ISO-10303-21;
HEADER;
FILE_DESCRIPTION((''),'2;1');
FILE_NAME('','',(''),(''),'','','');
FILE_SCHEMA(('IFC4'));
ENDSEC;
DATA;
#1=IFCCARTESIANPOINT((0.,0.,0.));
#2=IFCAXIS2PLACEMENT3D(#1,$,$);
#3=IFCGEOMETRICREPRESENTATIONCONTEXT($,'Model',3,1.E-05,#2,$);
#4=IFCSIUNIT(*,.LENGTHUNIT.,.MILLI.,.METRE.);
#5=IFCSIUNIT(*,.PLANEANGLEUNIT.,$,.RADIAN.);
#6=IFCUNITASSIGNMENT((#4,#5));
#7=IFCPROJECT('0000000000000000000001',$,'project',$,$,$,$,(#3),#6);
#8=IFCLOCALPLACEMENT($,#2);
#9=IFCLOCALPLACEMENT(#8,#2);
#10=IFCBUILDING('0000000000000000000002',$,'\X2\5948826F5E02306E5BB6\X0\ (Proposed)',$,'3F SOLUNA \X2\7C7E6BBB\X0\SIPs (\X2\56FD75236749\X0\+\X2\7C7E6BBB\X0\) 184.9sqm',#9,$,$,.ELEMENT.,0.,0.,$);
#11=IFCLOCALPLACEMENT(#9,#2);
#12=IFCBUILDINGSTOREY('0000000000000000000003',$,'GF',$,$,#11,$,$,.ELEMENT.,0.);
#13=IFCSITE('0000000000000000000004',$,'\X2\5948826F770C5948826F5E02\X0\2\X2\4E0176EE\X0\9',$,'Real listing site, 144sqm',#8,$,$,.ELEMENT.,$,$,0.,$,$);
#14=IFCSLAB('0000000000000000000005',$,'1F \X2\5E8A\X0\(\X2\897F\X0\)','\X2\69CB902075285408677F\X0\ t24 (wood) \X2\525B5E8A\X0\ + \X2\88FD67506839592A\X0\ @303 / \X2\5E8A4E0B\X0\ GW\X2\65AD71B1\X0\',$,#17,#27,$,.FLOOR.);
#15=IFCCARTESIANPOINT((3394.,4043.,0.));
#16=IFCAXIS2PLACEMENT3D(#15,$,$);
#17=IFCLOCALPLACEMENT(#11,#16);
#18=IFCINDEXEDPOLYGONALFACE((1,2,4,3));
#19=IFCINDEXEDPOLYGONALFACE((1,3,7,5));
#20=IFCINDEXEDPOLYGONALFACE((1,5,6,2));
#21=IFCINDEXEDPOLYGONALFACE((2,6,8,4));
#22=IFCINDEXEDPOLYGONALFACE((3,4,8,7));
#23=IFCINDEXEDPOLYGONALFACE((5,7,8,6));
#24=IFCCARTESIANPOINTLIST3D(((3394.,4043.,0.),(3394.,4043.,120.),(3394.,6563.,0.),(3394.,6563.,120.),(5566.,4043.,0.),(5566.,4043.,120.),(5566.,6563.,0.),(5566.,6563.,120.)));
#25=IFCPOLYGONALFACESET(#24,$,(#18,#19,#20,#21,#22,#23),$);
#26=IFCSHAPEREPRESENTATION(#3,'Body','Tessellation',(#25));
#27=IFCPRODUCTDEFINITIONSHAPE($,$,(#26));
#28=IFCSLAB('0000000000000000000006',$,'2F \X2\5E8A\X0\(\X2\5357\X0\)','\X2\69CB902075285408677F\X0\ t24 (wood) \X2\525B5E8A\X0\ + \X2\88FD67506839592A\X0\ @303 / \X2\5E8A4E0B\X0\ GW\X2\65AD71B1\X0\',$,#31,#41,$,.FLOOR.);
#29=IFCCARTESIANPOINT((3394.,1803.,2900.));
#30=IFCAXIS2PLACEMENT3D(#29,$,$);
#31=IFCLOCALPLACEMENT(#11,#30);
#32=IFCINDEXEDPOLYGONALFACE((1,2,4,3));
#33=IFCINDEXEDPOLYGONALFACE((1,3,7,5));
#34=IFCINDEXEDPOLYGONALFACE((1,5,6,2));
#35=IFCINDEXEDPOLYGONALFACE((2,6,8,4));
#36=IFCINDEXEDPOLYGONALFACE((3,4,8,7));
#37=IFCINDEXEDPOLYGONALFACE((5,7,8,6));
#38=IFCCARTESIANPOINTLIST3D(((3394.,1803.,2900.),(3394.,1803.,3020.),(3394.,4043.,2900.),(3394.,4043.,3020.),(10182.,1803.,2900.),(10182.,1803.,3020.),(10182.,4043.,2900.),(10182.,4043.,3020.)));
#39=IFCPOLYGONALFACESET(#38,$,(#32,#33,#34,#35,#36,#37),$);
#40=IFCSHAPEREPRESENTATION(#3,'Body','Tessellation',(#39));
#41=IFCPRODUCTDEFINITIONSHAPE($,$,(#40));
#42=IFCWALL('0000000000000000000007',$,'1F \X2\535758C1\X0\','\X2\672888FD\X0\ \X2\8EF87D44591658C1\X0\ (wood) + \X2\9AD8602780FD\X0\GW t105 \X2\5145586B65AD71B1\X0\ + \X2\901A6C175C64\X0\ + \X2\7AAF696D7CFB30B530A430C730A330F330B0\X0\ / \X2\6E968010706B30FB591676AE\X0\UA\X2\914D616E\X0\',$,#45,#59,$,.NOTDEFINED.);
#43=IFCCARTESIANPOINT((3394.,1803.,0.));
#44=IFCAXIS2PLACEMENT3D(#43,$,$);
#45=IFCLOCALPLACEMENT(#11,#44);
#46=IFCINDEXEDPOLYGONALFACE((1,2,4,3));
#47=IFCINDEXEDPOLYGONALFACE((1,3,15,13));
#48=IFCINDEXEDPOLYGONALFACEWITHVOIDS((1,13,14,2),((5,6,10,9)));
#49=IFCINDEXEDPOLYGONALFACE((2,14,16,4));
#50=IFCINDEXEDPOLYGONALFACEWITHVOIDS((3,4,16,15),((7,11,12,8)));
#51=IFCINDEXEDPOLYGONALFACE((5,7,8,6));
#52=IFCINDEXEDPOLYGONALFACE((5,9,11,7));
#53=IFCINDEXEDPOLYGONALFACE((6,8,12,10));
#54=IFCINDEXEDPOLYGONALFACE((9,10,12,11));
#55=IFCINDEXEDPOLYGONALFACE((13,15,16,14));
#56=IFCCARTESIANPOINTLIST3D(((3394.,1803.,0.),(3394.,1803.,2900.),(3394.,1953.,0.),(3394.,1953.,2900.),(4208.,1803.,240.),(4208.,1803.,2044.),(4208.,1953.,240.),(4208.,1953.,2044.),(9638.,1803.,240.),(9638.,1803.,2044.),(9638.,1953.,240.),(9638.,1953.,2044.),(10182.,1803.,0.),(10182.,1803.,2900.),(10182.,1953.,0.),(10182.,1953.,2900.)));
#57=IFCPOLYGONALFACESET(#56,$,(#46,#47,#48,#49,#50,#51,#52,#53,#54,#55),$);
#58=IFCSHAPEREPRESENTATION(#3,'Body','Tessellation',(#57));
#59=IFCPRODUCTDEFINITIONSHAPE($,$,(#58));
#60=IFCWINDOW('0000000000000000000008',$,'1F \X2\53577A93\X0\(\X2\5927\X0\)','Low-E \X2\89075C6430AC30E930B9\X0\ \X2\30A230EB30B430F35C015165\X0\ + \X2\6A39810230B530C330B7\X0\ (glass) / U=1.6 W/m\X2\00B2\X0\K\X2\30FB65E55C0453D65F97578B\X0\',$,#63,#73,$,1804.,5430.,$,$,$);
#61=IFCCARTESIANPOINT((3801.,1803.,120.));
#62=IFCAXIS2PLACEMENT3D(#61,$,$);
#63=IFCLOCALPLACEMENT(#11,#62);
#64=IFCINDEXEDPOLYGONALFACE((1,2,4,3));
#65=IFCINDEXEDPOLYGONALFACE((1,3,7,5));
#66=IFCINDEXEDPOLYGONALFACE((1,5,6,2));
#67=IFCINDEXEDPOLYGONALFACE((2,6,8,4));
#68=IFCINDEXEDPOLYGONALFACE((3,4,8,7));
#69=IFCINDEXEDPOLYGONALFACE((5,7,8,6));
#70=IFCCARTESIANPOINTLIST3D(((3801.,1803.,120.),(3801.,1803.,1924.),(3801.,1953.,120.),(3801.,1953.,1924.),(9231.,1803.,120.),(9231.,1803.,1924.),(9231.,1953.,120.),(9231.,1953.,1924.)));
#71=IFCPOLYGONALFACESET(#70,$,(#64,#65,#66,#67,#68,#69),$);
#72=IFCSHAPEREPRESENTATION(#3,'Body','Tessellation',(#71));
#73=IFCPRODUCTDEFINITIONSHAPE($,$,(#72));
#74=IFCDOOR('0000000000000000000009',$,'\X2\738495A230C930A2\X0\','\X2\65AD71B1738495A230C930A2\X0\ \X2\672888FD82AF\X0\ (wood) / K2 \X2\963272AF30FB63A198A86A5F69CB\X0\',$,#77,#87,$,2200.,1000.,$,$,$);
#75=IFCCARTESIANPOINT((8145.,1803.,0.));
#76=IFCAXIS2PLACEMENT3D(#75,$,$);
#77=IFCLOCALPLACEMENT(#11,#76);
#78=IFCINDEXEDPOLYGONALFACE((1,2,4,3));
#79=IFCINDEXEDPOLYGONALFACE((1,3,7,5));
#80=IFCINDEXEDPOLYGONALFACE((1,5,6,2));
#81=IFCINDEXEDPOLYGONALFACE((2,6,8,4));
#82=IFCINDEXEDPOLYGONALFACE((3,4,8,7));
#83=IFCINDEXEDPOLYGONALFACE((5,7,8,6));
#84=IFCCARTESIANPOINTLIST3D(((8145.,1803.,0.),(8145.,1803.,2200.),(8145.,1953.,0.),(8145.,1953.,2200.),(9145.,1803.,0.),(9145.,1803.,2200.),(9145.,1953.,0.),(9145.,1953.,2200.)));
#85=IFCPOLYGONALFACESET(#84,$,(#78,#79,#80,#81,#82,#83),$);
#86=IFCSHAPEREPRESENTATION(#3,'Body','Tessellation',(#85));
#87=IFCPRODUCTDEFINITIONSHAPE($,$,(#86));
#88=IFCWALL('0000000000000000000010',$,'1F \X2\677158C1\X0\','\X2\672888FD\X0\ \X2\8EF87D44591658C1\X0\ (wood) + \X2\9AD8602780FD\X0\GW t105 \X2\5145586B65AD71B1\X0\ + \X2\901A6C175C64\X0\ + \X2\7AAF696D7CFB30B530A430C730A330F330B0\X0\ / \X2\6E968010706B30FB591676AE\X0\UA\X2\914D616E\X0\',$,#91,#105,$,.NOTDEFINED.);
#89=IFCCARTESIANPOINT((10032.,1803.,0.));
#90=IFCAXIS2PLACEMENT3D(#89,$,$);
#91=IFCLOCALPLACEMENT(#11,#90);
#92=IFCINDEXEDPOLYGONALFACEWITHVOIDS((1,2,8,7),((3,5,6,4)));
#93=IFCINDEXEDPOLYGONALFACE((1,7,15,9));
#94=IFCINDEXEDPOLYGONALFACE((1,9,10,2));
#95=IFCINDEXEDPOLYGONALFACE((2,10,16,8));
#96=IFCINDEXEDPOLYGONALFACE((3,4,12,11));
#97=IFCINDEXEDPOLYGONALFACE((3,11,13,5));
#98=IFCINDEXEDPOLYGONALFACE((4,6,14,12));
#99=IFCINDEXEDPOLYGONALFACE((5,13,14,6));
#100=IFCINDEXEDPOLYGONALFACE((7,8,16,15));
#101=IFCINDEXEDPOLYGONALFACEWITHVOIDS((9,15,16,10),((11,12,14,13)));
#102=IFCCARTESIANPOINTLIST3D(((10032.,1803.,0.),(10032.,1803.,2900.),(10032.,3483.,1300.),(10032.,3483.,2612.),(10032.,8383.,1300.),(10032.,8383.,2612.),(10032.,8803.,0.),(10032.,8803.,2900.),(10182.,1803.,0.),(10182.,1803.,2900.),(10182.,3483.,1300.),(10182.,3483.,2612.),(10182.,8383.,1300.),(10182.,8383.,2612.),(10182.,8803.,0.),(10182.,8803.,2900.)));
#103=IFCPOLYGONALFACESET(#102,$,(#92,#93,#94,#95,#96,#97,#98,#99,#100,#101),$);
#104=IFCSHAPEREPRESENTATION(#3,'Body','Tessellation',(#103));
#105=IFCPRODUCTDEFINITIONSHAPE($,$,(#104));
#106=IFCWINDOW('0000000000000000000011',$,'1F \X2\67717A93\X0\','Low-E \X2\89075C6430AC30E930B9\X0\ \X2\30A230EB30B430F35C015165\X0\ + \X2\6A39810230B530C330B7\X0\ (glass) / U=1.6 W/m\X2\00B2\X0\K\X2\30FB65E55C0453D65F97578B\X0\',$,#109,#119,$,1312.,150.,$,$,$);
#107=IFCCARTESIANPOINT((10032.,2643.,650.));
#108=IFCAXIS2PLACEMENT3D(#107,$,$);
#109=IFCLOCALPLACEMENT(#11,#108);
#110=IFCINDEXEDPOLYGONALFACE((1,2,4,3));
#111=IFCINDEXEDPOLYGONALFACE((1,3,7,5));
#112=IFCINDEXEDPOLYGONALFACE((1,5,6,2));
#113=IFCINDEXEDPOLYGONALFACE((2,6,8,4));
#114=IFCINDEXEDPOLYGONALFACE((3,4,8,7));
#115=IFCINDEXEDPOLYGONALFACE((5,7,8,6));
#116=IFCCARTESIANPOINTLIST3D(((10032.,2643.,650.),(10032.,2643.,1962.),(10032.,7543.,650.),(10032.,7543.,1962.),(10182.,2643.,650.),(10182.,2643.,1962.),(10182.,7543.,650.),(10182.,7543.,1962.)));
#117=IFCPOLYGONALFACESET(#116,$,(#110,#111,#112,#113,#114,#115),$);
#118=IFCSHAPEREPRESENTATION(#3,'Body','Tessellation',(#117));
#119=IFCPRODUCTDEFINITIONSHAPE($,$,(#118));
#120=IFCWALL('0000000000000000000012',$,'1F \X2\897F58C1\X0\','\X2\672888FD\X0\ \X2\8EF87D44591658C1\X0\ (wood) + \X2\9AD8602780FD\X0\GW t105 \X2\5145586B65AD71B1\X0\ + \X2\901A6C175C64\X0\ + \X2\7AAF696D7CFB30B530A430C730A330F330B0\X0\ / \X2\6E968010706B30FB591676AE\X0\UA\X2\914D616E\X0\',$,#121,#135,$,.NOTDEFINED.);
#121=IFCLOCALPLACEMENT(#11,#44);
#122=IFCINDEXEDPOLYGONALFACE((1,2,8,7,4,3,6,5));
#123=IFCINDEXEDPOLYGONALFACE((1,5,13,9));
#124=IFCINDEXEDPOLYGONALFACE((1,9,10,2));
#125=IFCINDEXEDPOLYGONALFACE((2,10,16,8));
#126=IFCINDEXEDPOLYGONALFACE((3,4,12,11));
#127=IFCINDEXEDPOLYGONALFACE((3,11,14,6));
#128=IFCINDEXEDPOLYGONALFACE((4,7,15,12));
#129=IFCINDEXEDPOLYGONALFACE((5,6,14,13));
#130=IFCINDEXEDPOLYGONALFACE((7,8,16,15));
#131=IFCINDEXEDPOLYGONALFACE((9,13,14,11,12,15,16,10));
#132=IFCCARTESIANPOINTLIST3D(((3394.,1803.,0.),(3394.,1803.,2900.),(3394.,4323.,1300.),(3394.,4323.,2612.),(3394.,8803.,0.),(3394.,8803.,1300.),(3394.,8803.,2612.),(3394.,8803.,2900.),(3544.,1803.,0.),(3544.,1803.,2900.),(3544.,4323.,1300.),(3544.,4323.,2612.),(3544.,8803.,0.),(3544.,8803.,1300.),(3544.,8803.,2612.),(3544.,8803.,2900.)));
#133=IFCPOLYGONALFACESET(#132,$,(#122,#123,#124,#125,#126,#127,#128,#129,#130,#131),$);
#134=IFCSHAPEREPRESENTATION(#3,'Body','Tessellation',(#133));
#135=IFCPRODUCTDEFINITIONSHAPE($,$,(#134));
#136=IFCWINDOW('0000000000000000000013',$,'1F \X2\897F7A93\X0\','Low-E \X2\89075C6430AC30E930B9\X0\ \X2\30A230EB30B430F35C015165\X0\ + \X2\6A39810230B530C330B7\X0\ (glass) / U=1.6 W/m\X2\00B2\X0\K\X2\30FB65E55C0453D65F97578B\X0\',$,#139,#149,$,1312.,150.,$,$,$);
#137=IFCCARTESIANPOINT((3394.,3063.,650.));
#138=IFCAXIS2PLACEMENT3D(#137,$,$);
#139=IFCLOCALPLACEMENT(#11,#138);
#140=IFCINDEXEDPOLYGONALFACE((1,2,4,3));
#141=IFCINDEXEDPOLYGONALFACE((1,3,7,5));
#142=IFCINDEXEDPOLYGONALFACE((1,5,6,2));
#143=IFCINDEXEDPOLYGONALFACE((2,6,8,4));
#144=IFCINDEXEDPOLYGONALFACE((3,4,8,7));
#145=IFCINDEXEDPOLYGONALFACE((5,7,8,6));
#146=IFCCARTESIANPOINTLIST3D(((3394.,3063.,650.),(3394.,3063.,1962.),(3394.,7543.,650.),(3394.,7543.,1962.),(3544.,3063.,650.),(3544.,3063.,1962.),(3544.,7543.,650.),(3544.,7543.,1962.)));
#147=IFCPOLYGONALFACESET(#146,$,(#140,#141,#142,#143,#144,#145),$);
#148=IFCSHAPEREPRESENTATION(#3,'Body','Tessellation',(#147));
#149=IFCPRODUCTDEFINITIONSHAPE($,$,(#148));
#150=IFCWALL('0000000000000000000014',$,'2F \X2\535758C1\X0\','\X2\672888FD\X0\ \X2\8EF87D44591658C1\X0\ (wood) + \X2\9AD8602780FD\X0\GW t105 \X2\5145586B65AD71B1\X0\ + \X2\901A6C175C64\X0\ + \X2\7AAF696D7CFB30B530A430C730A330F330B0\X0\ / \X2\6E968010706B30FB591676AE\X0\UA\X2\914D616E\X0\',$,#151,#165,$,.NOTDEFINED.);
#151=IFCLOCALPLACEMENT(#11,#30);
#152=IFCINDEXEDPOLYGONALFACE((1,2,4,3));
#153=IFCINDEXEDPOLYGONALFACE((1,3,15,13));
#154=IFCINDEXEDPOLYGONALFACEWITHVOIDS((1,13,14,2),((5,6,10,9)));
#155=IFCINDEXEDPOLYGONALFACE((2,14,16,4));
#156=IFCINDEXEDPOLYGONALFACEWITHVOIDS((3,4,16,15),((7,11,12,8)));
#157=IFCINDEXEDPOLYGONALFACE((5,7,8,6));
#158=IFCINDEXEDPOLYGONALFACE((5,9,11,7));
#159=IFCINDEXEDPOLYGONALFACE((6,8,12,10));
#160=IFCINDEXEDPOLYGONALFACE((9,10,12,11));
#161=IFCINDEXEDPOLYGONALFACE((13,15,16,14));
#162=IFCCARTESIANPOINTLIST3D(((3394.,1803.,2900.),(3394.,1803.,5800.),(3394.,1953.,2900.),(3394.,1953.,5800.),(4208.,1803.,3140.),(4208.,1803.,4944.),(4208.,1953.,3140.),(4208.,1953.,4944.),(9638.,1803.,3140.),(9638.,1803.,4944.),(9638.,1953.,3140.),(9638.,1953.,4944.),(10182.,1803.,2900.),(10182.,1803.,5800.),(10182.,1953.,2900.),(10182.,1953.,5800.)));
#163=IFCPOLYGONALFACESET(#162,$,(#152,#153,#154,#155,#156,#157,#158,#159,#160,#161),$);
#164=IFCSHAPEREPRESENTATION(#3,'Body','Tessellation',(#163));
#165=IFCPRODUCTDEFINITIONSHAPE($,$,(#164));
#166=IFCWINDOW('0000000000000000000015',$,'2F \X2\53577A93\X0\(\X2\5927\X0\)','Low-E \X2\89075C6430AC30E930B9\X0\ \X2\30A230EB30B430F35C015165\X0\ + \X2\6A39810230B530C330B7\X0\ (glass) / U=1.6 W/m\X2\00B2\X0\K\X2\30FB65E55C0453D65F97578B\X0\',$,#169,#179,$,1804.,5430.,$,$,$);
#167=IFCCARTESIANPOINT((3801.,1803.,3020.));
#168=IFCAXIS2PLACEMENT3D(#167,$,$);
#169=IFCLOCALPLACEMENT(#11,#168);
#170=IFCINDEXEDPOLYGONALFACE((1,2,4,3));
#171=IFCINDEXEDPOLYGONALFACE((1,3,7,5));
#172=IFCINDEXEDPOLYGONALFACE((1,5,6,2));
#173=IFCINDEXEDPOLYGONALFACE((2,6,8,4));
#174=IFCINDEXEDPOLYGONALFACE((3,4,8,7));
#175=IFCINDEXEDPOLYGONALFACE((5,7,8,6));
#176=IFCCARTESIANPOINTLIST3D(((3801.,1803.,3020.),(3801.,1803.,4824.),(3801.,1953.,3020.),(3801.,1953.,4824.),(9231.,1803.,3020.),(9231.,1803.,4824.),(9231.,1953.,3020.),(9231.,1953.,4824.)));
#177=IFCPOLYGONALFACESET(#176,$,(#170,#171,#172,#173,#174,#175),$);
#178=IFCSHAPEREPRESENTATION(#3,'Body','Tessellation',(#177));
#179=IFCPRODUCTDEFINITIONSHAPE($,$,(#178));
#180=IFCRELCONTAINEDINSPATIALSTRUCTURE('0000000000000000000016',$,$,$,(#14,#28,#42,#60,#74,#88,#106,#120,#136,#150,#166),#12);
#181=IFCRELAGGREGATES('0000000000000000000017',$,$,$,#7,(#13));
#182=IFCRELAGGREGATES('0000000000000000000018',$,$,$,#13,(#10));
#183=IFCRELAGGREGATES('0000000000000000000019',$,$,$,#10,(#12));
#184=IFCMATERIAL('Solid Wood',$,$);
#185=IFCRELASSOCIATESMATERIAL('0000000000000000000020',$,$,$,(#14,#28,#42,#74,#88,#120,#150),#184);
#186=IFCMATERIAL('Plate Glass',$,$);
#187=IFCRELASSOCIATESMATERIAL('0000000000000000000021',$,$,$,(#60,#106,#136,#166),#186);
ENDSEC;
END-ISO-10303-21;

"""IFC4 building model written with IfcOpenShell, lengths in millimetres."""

from ifc_helpers import new_model, si_unit, frame, frame_2d, origin, place, context, project, spatial, rectangle, extrude, material, element, fill, save


model = new_model("IFC4")

# Units and contexts
model_context = context("Model", 3, precision=1e-05, world=origin())
ifc_project = project(units=[si_unit("LENGTHUNIT", "METRE", prefix="MILLI"), si_unit("PLANEANGLEUNIT", "RADIAN")], contexts=[model_context])

# Site, building, storey
site_placement = place(None, origin())
site = spatial("IfcSite", under=ifc_project, at=site_placement, Name="奈良県奈良市2丁目9", ObjectType="Real listing site, 144sqm", CompositionType="ELEMENT", RefElevation=0.0)
building_placement = place(site_placement, origin())
building = spatial("IfcBuilding", under=site, at=building_placement, Name="奈良市の家 (Proposed)", ObjectType="3F SOLUNA 籾殻SIPs (国産杉+籾殻) 184.9sqm", CompositionType="ELEMENT", ElevationOfRefHeight=0.0, ElevationOfTerrain=0.0)
storey_placement = place(building_placement, origin())
storey = spatial("IfcBuildingStorey", under=building, at=storey_placement, Name="GF", CompositionType="ELEMENT", Elevation=0.0)

# Slabs
ifc_material_1 = material(Name="Solid Wood")
slab_1_placement = place(storey_placement, frame((3394.0, 4043.0, 0.0)))
element("IfcSlab", 1, at=slab_1_placement, inside=storey, material=ifc_material_1, Name="1F 床(西)", Description="構造用合板 t24 (wood) 剛床 + 製材根太 @303 / 床下 GW断熱", PredefinedType="FLOOR", context=model_context, shape_type="SweptSolid", body=[
    extrude(rectangle(XDim=2172.0, YDim=2520.0, at=frame_2d((1086.0, 1260.0))), frame((3394.0, 4043.0, 0.0)), (0.0, 0.0, 1.0), 120.0),
])
slab_2_placement = place(storey_placement, frame((3394.0, 1803.0, 2900.0)))
element("IfcSlab", 2, at=slab_2_placement, inside=storey, material=ifc_material_1, Name="2F 床(南)", Description="構造用合板 t24 (wood) 剛床 + 製材根太 @303 / 床下 GW断熱", PredefinedType="FLOOR", context=model_context, shape_type="SweptSolid", body=[
    extrude(rectangle(XDim=6788.0, YDim=2240.0, at=frame_2d((3394.0, 1120.0))), frame((3394.0, 1803.0, 2900.0)), (0.0, 0.0, 1.0), 120.0),
])

# Wall, openings, window, door
wall_1_placement = place(storey_placement, frame((3394.0, 1803.0, 0.0)))
wall_1 = element("IfcWall", 3, at=wall_1_placement, inside=storey, material=ifc_material_1, Name="1F 南壁", Description="木製 軸組外壁 (wood) + 高性能GW t105 充填断熱 + 通気層 + 窯業系サイディング / 準耐火・外皮UA配慮", PredefinedType="NOTDEFINED", context=model_context, shape_type="SweptSolid", body=[
    extrude(rectangle(XDim=6788.0, YDim=150.0, at=frame_2d((3394.0, 75.0))), frame((3394.0, 1803.0, 0.0)), (0.0, 0.0, 1.0), 2900.0),
])
opening_1_placement = place(storey_placement, frame((3801.0, 1803.0, 120.0)))
opening_1 = element("IfcOpeningElement", 4, at=opening_1_placement, cuts=wall_1, PredefinedType="NOTDEFINED", context=model_context, shape_type="SweptSolid", body=[
    extrude(rectangle(XDim=5430.0, YDim=150.0, at=frame_2d((2715.0, 75.0))), frame((3801.0, 1803.0, 120.0)), (0.0, 0.0, 1.0), 1804.0),
])
opening_2_placement = place(storey_placement, frame((8145.0, 1803.0, 0.0)))
opening_2 = element("IfcOpeningElement", 5, at=opening_2_placement, cuts=wall_1, PredefinedType="NOTDEFINED", context=model_context, shape_type="SweptSolid", body=[
    extrude(rectangle(XDim=1000.0, YDim=150.0, at=frame_2d((500.0, 75.0))), frame((8145.0, 1803.0, 0.0)), (0.0, 0.0, 1.0), 2200.0),
])
ifc_material_2 = material(Name="Plate Glass")
window_1_placement = place(storey_placement, frame((3801.0, 1803.0, 120.0)))
window_1 = element("IfcWindow", 6, at=window_1_placement, inside=storey, material=ifc_material_2, Name="1F 南窓(大)", Description="Low-E 複層ガラス アルゴン封入 + 樹脂サッシ (glass) / U=1.6 W/m²K・日射取得型", OverallHeight=1804.0, OverallWidth=5430.0, context=model_context, shape_type="SweptSolid", body=[
    extrude(rectangle(XDim=5430.0, YDim=150.0, at=frame_2d((2715.0, 75.0))), frame((3801.0, 1803.0, 120.0)), (0.0, 0.0, 1.0), 1804.0),
])
fill(opening_1, window_1)
door_placement = place(storey_placement, frame((8145.0, 1803.0, 0.0)))
door = element("IfcDoor", 7, at=door_placement, inside=storey, material=ifc_material_1, Name="玄関ドア", Description="断熱玄関ドア 木製芯 (wood) / K2 防犯・採風機構", OverallHeight=2200.0, OverallWidth=1000.0, context=model_context, shape_type="SweptSolid", body=[
    extrude(rectangle(XDim=1000.0, YDim=150.0, at=frame_2d((500.0, 75.0))), frame((8145.0, 1803.0, 0.0)), (0.0, 0.0, 1.0), 2200.0),
])
fill(opening_2, door)

# Walls, openings, windows
wall_2_placement = place(storey_placement, frame((10032.0, 1803.0, 0.0)))
wall_2 = element("IfcWall", 8, at=wall_2_placement, inside=storey, material=ifc_material_1, Name="1F 東壁", Description="木製 軸組外壁 (wood) + 高性能GW t105 充填断熱 + 通気層 + 窯業系サイディング / 準耐火・外皮UA配慮", PredefinedType="NOTDEFINED", context=model_context, shape_type="SweptSolid", body=[
    extrude(rectangle(XDim=150.0, YDim=7000.0, at=frame_2d((75.0, 3500.0))), frame((10032.0, 1803.0, 0.0)), (0.0, 0.0, 1.0), 2900.0),
])
opening_3_placement = place(storey_placement, frame((10032.0, 2643.0, 650.0)))
opening_3 = element("IfcOpeningElement", 9, at=opening_3_placement, cuts=wall_2, PredefinedType="NOTDEFINED", context=model_context, shape_type="SweptSolid", body=[
    extrude(rectangle(XDim=150.0, YDim=4900.0, at=frame_2d((75.0, 2450.0))), frame((10032.0, 2643.0, 650.0)), (0.0, 0.0, 1.0), 1312.0),
])
window_2_placement = place(storey_placement, frame((10032.0, 2643.0, 650.0)))
window_2 = element("IfcWindow", 10, at=window_2_placement, inside=storey, material=ifc_material_2, Name="1F 東窓", Description="Low-E 複層ガラス アルゴン封入 + 樹脂サッシ (glass) / U=1.6 W/m²K・日射取得型", OverallHeight=1312.0, OverallWidth=150.0, context=model_context, shape_type="SweptSolid", body=[
    extrude(rectangle(XDim=150.0, YDim=4900.0, at=frame_2d((75.0, 2450.0))), frame((10032.0, 2643.0, 650.0)), (0.0, 0.0, 1.0), 1312.0),
])
fill(opening_3, window_2)
wall_3_placement = place(storey_placement, frame((3394.0, 1803.0, 0.0)))
wall_3 = element("IfcWall", 11, at=wall_3_placement, inside=storey, material=ifc_material_1, Name="1F 西壁", Description="木製 軸組外壁 (wood) + 高性能GW t105 充填断熱 + 通気層 + 窯業系サイディング / 準耐火・外皮UA配慮", PredefinedType="NOTDEFINED", context=model_context, shape_type="SweptSolid", body=[
    extrude(rectangle(XDim=150.0, YDim=7000.0, at=frame_2d((75.0, 3500.0))), frame((3394.0, 1803.0, 0.0)), (0.0, 0.0, 1.0), 2900.0),
])
opening_4_placement = place(storey_placement, frame((3394.0, 3063.0, 650.0)))
opening_4 = element("IfcOpeningElement", 12, at=opening_4_placement, cuts=wall_3, PredefinedType="NOTDEFINED", context=model_context, shape_type="SweptSolid", body=[
    extrude(rectangle(XDim=150.0, YDim=4480.0, at=frame_2d((75.0, 2240.0))), frame((3394.0, 3063.0, 650.0)), (0.0, 0.0, 1.0), 1312.0),
])
window_3_placement = place(storey_placement, frame((3394.0, 3063.0, 650.0)))
window_3 = element("IfcWindow", 13, at=window_3_placement, inside=storey, material=ifc_material_2, Name="1F 西窓", Description="Low-E 複層ガラス アルゴン封入 + 樹脂サッシ (glass) / U=1.6 W/m²K・日射取得型", OverallHeight=1312.0, OverallWidth=150.0, context=model_context, shape_type="SweptSolid", body=[
    extrude(rectangle(XDim=150.0, YDim=4480.0, at=frame_2d((75.0, 2240.0))), frame((3394.0, 3063.0, 650.0)), (0.0, 0.0, 1.0), 1312.0),
])
fill(opening_4, window_3)
wall_4_placement = place(storey_placement, frame((3394.0, 1803.0, 2900.0)))
wall_4 = element("IfcWall", 14, at=wall_4_placement, inside=storey, material=ifc_material_1, Name="2F 南壁", Description="木製 軸組外壁 (wood) + 高性能GW t105 充填断熱 + 通気層 + 窯業系サイディング / 準耐火・外皮UA配慮", PredefinedType="NOTDEFINED", context=model_context, shape_type="SweptSolid", body=[
    extrude(rectangle(XDim=6788.0, YDim=150.0, at=frame_2d((3394.0, 75.0))), frame((3394.0, 1803.0, 2900.0)), (0.0, 0.0, 1.0), 2900.0),
])
opening_5_placement = place(storey_placement, frame((3801.0, 1803.0, 3020.0)))
opening_5 = element("IfcOpeningElement", 15, at=opening_5_placement, cuts=wall_4, PredefinedType="NOTDEFINED", context=model_context, shape_type="SweptSolid", body=[
    extrude(rectangle(XDim=5430.0, YDim=150.0, at=frame_2d((2715.0, 75.0))), frame((3801.0, 1803.0, 3020.0)), (0.0, 0.0, 1.0), 1804.0),
])
window_4_placement = place(storey_placement, frame((3801.0, 1803.0, 3020.0)))
window_4 = element("IfcWindow", 16, at=window_4_placement, inside=storey, material=ifc_material_2, Name="2F 南窓(大)", Description="Low-E 複層ガラス アルゴン封入 + 樹脂サッシ (glass) / U=1.6 W/m²K・日射取得型", OverallHeight=1804.0, OverallWidth=5430.0, context=model_context, shape_type="SweptSolid", body=[
    extrude(rectangle(XDim=5430.0, YDim=150.0, at=frame_2d((2715.0, 75.0))), frame((3801.0, 1803.0, 3020.0)), (0.0, 0.0, 1.0), 1804.0),
])
fill(opening_5, window_4)

save(model, "model.ifc")
